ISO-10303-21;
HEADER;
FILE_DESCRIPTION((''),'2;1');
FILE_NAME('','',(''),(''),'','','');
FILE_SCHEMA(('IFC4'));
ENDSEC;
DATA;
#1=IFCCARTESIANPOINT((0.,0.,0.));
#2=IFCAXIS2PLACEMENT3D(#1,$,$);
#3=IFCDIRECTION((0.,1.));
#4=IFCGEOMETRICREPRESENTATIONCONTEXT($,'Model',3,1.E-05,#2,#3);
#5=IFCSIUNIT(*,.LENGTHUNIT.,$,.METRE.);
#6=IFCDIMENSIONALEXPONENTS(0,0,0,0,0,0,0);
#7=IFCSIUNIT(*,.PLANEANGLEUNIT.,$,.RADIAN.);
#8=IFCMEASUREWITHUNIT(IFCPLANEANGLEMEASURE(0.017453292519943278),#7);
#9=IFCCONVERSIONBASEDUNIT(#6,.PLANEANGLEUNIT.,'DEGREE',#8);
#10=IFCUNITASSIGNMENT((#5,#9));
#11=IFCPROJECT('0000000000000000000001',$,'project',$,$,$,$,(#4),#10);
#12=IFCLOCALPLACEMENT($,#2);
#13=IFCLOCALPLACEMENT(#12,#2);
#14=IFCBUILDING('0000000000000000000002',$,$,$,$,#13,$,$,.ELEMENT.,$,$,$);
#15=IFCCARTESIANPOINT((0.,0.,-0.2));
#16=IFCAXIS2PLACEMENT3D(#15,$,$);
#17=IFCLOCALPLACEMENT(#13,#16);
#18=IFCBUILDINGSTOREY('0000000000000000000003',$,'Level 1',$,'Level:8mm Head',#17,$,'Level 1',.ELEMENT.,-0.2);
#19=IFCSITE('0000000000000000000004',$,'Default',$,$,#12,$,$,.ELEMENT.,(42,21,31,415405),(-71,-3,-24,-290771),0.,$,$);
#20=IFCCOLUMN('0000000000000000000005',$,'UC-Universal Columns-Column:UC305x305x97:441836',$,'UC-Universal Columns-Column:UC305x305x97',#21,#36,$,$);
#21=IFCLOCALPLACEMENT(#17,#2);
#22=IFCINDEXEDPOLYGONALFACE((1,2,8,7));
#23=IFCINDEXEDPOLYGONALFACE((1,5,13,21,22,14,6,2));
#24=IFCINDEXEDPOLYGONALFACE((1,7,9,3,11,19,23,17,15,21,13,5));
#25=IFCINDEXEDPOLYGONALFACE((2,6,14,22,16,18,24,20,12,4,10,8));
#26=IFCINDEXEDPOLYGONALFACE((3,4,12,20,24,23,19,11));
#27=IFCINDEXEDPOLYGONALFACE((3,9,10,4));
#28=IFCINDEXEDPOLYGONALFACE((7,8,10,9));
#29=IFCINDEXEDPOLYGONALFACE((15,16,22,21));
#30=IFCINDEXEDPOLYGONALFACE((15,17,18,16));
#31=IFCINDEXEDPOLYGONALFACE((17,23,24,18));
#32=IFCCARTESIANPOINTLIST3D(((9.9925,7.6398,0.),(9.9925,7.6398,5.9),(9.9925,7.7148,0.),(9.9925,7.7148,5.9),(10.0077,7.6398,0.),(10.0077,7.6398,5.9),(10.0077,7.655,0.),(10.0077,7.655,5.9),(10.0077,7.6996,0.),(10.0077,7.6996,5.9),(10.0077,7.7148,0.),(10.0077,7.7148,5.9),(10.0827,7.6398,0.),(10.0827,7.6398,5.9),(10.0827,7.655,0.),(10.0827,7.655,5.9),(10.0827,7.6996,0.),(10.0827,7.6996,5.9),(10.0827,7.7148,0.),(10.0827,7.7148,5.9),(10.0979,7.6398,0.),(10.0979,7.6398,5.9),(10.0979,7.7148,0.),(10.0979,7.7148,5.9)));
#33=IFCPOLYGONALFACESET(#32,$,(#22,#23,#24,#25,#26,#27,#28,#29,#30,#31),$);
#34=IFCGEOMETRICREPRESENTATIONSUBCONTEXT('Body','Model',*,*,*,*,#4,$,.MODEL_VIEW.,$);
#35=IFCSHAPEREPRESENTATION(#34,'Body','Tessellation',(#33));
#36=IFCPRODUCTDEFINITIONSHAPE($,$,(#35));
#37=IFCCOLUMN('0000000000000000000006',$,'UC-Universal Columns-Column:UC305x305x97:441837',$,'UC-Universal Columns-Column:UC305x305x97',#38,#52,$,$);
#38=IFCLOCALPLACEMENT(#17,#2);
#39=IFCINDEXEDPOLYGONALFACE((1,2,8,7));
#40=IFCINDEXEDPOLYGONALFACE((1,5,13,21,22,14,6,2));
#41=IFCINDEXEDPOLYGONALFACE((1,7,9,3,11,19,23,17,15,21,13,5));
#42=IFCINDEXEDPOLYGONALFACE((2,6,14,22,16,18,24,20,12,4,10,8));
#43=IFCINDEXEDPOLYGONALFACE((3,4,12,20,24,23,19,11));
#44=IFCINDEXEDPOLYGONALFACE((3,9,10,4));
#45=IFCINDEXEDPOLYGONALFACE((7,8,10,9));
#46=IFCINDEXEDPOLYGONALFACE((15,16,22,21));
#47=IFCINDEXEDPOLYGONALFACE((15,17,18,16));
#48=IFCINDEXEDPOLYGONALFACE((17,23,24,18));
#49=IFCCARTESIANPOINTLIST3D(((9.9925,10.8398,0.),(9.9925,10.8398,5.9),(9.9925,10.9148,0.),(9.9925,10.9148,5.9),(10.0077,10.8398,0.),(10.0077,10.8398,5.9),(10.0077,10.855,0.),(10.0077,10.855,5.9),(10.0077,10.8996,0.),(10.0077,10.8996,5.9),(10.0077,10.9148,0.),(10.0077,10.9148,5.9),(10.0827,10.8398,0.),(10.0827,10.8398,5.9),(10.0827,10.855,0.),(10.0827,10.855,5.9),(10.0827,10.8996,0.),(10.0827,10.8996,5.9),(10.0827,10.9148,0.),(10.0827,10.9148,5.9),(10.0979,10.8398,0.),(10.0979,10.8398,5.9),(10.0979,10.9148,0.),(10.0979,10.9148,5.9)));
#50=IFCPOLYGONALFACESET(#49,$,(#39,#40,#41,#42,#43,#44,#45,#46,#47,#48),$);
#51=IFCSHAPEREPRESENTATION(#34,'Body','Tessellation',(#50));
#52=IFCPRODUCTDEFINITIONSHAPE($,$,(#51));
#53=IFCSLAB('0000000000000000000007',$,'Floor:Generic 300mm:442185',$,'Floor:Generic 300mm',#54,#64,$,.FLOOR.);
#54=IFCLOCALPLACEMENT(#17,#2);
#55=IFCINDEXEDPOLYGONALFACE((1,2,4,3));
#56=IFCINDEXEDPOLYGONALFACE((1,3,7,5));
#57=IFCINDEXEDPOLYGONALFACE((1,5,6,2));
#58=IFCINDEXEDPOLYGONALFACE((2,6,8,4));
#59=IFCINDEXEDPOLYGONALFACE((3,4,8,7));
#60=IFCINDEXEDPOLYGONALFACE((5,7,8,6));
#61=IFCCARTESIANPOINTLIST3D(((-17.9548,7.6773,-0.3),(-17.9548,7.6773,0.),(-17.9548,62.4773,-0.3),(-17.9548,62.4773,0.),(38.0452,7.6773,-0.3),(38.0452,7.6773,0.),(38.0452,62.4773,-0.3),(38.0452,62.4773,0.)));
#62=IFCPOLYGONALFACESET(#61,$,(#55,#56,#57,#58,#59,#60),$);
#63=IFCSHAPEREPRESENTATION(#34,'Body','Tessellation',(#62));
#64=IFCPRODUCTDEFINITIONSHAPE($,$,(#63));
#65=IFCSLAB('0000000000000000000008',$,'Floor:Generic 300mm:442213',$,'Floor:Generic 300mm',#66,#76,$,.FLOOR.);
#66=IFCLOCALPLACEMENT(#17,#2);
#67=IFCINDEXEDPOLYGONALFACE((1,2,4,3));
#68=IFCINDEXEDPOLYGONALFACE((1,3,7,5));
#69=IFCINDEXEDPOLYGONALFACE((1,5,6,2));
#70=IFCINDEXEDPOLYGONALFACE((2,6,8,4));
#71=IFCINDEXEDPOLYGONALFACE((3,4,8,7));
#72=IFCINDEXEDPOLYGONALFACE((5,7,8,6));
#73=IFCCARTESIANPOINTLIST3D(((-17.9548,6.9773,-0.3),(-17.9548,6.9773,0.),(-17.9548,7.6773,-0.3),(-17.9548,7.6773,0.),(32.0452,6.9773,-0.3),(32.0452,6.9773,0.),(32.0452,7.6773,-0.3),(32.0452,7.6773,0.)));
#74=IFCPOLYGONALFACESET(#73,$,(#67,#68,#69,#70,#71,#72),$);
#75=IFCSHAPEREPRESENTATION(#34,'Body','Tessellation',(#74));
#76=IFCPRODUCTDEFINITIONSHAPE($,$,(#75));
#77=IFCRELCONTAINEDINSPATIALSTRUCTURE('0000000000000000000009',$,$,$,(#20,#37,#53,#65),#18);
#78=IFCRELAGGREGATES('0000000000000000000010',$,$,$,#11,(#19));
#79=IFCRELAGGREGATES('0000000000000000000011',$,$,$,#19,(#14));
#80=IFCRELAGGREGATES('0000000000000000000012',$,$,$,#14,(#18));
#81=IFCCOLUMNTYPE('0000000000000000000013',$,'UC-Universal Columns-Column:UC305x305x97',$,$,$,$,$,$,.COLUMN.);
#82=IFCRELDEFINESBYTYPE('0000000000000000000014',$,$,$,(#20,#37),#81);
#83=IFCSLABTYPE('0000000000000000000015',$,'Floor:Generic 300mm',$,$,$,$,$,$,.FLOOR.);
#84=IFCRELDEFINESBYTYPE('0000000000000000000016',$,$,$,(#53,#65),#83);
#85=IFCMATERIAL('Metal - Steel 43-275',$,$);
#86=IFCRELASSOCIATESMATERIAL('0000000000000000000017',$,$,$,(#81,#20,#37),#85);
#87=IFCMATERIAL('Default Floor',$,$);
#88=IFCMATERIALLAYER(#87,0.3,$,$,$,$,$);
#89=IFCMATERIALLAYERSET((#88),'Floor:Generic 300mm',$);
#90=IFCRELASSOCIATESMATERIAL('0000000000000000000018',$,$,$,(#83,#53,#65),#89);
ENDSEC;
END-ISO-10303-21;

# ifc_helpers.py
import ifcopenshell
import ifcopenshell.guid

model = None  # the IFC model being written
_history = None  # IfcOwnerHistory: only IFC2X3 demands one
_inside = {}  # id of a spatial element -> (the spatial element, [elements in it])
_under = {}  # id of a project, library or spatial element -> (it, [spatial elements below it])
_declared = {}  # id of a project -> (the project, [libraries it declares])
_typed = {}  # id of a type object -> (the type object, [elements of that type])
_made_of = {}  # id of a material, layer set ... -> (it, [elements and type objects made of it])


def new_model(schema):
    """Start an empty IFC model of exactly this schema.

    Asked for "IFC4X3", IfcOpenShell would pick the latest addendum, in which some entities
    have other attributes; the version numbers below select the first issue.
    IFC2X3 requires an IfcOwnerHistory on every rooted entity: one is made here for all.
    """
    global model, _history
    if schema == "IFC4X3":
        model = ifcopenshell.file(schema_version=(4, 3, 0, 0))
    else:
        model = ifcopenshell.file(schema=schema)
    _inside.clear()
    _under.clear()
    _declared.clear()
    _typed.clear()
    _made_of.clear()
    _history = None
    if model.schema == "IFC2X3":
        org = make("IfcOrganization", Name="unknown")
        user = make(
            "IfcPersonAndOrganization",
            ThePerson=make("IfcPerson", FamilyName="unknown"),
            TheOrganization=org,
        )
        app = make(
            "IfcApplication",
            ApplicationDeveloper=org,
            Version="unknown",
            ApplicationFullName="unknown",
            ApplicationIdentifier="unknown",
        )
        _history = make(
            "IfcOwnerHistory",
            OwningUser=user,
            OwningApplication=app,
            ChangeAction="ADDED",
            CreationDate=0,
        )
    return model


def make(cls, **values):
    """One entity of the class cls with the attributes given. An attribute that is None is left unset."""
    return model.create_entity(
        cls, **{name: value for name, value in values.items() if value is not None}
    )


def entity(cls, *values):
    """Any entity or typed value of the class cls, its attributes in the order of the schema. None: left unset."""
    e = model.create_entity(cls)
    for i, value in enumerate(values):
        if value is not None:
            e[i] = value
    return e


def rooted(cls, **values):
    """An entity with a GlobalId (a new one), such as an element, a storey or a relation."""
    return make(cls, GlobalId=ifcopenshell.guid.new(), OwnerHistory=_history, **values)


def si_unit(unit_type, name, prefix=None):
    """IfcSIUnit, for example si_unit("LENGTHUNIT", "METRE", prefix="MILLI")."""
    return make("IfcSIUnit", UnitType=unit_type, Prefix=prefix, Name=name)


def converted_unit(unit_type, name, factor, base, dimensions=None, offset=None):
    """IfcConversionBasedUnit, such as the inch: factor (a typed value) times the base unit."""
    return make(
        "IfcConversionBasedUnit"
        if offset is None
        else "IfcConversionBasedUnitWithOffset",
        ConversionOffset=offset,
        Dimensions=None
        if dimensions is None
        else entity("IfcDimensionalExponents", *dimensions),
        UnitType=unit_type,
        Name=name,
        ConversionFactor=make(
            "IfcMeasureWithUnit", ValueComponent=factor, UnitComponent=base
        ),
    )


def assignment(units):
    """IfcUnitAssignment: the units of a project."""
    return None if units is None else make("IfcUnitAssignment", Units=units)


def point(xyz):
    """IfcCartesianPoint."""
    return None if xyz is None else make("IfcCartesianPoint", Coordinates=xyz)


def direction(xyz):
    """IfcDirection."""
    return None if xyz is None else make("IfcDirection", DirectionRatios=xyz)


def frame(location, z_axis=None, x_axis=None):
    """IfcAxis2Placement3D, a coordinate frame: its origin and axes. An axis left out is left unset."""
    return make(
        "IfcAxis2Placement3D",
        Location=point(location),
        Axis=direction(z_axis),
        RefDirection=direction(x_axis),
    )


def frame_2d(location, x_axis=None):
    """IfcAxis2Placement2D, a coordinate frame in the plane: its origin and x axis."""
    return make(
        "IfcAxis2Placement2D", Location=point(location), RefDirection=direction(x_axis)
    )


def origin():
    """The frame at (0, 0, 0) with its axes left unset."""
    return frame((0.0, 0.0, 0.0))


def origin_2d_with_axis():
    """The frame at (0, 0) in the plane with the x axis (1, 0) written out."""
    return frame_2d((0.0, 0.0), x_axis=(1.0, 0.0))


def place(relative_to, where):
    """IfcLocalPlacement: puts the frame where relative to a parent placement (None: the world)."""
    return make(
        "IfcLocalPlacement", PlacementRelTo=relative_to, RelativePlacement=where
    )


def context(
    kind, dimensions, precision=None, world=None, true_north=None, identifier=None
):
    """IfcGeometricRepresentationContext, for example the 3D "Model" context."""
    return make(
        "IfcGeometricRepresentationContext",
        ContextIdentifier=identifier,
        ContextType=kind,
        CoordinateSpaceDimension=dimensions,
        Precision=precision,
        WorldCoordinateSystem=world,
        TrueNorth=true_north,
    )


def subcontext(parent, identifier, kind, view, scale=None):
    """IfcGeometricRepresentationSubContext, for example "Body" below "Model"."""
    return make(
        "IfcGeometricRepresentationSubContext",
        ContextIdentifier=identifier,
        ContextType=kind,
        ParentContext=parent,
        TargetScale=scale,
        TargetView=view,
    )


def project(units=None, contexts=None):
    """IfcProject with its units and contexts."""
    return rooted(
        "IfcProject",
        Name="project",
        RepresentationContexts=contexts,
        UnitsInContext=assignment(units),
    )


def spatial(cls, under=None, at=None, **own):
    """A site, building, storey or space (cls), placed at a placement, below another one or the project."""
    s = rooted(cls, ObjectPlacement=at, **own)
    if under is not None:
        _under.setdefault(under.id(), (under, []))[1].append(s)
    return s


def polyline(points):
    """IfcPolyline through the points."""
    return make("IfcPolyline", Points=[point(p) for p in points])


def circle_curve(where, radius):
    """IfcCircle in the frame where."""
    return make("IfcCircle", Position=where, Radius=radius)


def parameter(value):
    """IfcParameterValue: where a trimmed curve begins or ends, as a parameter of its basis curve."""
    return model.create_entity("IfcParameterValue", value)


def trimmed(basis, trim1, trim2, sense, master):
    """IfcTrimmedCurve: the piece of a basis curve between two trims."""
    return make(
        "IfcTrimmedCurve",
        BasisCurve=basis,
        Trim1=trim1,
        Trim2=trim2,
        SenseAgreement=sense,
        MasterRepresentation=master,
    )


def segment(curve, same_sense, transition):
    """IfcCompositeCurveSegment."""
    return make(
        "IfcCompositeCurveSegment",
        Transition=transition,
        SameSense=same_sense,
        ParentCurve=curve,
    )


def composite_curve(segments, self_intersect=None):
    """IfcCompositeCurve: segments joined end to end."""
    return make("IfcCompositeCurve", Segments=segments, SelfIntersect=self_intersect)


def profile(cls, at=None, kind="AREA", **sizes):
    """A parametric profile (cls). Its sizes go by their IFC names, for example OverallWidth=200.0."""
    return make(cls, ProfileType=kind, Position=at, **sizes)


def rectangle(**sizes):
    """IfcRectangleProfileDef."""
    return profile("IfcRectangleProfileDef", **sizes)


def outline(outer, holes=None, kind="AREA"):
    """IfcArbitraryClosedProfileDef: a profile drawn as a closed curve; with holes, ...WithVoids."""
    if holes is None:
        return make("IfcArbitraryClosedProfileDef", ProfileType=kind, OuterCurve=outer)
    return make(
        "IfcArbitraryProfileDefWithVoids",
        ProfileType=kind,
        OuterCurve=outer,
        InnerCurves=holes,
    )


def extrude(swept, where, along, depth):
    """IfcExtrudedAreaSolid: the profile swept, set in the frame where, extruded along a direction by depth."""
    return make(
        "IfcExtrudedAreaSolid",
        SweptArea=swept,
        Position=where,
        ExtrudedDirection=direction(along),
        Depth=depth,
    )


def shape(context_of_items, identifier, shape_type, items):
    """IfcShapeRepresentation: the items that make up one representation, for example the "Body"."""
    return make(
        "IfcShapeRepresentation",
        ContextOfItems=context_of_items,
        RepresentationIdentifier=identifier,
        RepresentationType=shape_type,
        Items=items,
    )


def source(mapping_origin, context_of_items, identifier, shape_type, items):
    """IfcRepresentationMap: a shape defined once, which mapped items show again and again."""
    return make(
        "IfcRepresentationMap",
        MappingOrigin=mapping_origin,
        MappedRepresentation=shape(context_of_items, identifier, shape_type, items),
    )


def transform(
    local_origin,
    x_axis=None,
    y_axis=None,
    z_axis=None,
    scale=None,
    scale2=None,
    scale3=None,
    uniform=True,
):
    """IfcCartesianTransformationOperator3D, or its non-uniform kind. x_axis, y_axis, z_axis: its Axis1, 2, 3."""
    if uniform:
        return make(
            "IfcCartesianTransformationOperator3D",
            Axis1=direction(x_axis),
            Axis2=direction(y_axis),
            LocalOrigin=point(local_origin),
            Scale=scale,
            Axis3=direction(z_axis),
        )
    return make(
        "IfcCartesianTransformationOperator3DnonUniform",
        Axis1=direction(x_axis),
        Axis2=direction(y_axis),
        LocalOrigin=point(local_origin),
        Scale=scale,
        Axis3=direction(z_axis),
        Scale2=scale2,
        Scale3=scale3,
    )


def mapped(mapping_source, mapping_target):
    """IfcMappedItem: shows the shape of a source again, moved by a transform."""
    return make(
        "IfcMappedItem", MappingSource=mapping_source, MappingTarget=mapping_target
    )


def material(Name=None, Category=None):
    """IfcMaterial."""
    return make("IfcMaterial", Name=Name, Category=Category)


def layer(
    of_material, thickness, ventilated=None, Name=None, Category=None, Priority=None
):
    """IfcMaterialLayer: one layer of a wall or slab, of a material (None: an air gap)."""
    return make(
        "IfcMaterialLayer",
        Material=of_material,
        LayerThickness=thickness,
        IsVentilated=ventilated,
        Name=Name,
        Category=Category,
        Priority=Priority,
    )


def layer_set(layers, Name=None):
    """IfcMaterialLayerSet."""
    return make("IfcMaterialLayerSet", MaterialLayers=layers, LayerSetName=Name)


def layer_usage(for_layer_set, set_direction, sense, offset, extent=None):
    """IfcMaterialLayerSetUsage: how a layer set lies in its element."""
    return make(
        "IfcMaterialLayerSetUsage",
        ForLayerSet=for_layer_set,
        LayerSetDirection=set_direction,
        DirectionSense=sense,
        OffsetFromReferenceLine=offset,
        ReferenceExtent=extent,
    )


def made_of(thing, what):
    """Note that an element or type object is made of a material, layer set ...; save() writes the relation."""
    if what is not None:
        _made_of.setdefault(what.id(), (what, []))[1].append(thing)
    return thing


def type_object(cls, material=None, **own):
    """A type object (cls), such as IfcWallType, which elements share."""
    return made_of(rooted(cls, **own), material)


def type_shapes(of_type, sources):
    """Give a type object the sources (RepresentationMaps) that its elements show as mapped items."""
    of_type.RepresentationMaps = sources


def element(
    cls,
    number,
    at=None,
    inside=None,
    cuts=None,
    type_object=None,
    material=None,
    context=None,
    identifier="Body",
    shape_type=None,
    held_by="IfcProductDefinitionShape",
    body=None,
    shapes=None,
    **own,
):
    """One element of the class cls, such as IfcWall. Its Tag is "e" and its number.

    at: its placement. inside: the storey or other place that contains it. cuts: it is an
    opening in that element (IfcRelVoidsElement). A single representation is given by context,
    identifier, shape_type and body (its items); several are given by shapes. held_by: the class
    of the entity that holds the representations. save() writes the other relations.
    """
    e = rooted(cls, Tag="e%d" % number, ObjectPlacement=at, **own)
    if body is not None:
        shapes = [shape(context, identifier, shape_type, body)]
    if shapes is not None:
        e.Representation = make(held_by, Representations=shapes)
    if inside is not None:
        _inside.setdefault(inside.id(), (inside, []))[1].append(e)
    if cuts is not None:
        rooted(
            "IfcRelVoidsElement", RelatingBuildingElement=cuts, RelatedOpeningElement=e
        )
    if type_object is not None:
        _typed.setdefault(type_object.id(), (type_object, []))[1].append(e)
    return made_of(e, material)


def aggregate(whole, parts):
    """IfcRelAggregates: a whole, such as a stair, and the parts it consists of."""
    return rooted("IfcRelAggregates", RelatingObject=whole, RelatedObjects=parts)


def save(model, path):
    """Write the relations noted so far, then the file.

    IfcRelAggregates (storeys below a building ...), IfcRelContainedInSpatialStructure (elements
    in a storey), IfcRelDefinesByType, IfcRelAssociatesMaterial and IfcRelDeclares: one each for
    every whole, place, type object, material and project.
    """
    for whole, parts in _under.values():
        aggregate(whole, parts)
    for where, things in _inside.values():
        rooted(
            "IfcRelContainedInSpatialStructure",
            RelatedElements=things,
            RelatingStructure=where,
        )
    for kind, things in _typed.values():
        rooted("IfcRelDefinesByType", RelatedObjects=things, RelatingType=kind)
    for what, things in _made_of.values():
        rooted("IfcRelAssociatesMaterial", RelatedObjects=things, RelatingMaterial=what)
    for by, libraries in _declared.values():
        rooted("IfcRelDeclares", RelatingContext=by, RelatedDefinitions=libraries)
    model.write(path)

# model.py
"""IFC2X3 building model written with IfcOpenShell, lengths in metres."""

from ifc_helpers import new_model, entity, si_unit, converted_unit, direction, frame, frame_2d, origin, origin_2d_with_axis, place, context, subcontext, project, spatial, polyline, circle_curve, parameter, trimmed, segment, composite_curve, rectangle, outline, extrude, source, transform, mapped, material, layer, layer_set, layer_usage, type_object, type_shapes, element, save


model = new_model("IFC2X3")

# Units and contexts
model_context = context("Model", 3, precision=1e-05, world=origin(), true_north=direction((0.0, 1.0)))
body_context = subcontext(model_context, "Body", "Model", "MODEL_VIEW")
ifc_project = project(units=[si_unit("LENGTHUNIT", "METRE"), converted_unit("PLANEANGLEUNIT", "DEGREE", entity("IfcPlaneAngleMeasure", 0.017453292519943278), si_unit("PLANEANGLEUNIT", "RADIAN"), dimensions=[0, 0, 0, 0, 0, 0, 0])], contexts=[model_context])

# Site, building, storey
site_placement = place(None, origin())
site = spatial("IfcSite", under=ifc_project, at=site_placement, Name="Default", CompositionType="ELEMENT", RefLatitude=(42, 21, 31, 415405), RefLongitude=(-71, -3, -24, -290771), RefElevation=0.0)
building_placement = place(site_placement, origin())
building = spatial("IfcBuilding", under=site, at=building_placement, CompositionType="ELEMENT")
storey_placement = place(building_placement, frame((0.0, 0.0, -0.2)))
storey = spatial("IfcBuildingStorey", under=building, at=storey_placement, Name="Level 1", ObjectType="Level:8mm Head", LongName="Level 1", CompositionType="ELEMENT", Elevation=-0.2)

# Columns
ifc_material_1 = material(Name="Metal - Steel 43-275")
column_type_1 = type_object("IfcColumnType", Name="UC-Universal Columns-Column:UC305x305x97", PredefinedType="COLUMN", material=ifc_material_1)
shared_shape_1 = source(origin(), body_context, "Body", "SweptSolid", [
    extrude(outline(composite_curve([segment(polyline([(-0.0375, -0.0375), (0.0375, -0.0375)]), True, "CONTINUOUS"), segment(polyline([(0.0375, -0.0375), (0.0527, -0.0375)]), True, "CONTINUOUS"), segment(trimmed(circle_curve(frame_2d((0.0527, -0.0223), x_axis=(-1.0, 0.0)), 0.0152), [parameter(0.0)], [parameter(90.0)], True, "PARAMETER"), False, "CONTINUOUS"), segment(polyline([(0.0375, -0.0223), (0.0375, 0.0223)]), True, "CONTINUOUS"), segment(trimmed(circle_curve(frame_2d((0.0527, 0.0223), x_axis=(-1.0, 0.0)), 0.0152), [parameter(270.0)], [parameter(0.0)], True, "PARAMETER"), False, "CONTINUOUS"), segment(polyline([(0.0527, 0.0375), (0.0375, 0.0375)]), True, "CONTINUOUS"), segment(polyline([(0.0375, 0.0375), (-0.0375, 0.0375)]), True, "CONTINUOUS"), segment(polyline([(-0.0375, 0.0375), (-0.0527, 0.0375)]), True, "CONTINUOUS"), segment(trimmed(circle_curve(frame_2d((-0.0527, 0.0223), x_axis=(-1.0, 0.0)), 0.0152), [parameter(180.0)], [parameter(270.0)], True, "PARAMETER"), False, "CONTINUOUS"), segment(polyline([(-0.0375, 0.0223), (-0.0375, -0.0223)]), True, "CONTINUOUS"), segment(trimmed(circle_curve(frame_2d((-0.0527, -0.0223), x_axis=(-1.0, 0.0)), 0.0152), [parameter(90.0)], [parameter(180.0)], True, "PARAMETER"), False, "CONTINUOUS"), segment(polyline([(-0.0527, -0.0375), (-0.0375, -0.0375)]), True, "CONTINUOUS")], self_intersect=False)), frame((0.0, 0.0, -0.2), z_axis=(0.0, 0.0, 1.0), x_axis=(-1.0, 0.0, 0.0)), (0.0, 0.0, 1.0), 5.9),
])
type_shapes(column_type_1, [shared_shape_1])
for number, where, z_axis, x_axis, name in (
    (1, (10.0452, 7.6773, 0.2), (0.0, 0.0, 1.0), (-1.0, 0.0, 0.0), "UC-Universal Columns-Column:UC305x305x97:441836"),
    (2, (10.0452, 10.8773, 0.2), (0.0, 0.0, 1.0), (-1.0, 0.0, 0.0), "UC-Universal Columns-Column:UC305x305x97:441837"),
):
    element("IfcColumn", number, at=place(storey_placement, frame(where, z_axis=z_axis, x_axis=x_axis)), inside=storey, type_object=column_type_1, material=ifc_material_1, Name=name, ObjectType="UC-Universal Columns-Column:UC305x305x97", context=body_context, shape_type="MappedRepresentation", body=[
        mapped(shared_shape_1, transform((0.0, 0.0, 0.0), scale=1.0)),
    ])

# Slabs
ifc_material_2 = material(Name="Default Floor")
ifc_layer = layer(ifc_material_2, 0.3)
ifc_layer_set = layer_set([ifc_layer], Name="Floor:Generic 300mm")
ifc_layer_usage_1 = layer_usage(ifc_layer_set, "AXIS3", "POSITIVE", 0.0)
slab_type = type_object("IfcSlabType", Name="Floor:Generic 300mm", PredefinedType="FLOOR", material=ifc_layer_set)
slab_1_placement = place(storey_placement, origin())
element("IfcSlab", 3, at=slab_1_placement, inside=storey, type_object=slab_type, material=ifc_layer_usage_1, Name="Floor:Generic 300mm:442185", ObjectType="Floor:Generic 300mm", PredefinedType="FLOOR", context=body_context, shape_type="SweptSolid", body=[
    extrude(rectangle(XDim=54.8, YDim=56.0, at=origin_2d_with_axis()), frame((10.0452, 35.0773, 0.0), z_axis=(0.0, 0.0, -1.0), x_axis=(0.0, 1.0, 0.0)), (0.0, 0.0, 1.0), 0.3),
])
ifc_layer_usage_2 = layer_usage(ifc_layer_set, "AXIS3", "POSITIVE", 0.0)
slab_2_placement = place(storey_placement, origin())
element("IfcSlab", 4, at=slab_2_placement, inside=storey, type_object=slab_type, material=ifc_layer_usage_2, Name="Floor:Generic 300mm:442213", ObjectType="Floor:Generic 300mm", PredefinedType="FLOOR", context=body_context, shape_type="SweptSolid", body=[
    extrude(rectangle(XDim=0.7, YDim=50.0, at=frame_2d((0.0, 0.0), x_axis=(1.0, 0.0))), frame((7.0452, 7.3273, 0.0), z_axis=(0.0, 0.0, -1.0), x_axis=(0.0, 1.0, 0.0)), (0.0, 0.0, 1.0), 0.3),
])

save(model, "model.ifc")
